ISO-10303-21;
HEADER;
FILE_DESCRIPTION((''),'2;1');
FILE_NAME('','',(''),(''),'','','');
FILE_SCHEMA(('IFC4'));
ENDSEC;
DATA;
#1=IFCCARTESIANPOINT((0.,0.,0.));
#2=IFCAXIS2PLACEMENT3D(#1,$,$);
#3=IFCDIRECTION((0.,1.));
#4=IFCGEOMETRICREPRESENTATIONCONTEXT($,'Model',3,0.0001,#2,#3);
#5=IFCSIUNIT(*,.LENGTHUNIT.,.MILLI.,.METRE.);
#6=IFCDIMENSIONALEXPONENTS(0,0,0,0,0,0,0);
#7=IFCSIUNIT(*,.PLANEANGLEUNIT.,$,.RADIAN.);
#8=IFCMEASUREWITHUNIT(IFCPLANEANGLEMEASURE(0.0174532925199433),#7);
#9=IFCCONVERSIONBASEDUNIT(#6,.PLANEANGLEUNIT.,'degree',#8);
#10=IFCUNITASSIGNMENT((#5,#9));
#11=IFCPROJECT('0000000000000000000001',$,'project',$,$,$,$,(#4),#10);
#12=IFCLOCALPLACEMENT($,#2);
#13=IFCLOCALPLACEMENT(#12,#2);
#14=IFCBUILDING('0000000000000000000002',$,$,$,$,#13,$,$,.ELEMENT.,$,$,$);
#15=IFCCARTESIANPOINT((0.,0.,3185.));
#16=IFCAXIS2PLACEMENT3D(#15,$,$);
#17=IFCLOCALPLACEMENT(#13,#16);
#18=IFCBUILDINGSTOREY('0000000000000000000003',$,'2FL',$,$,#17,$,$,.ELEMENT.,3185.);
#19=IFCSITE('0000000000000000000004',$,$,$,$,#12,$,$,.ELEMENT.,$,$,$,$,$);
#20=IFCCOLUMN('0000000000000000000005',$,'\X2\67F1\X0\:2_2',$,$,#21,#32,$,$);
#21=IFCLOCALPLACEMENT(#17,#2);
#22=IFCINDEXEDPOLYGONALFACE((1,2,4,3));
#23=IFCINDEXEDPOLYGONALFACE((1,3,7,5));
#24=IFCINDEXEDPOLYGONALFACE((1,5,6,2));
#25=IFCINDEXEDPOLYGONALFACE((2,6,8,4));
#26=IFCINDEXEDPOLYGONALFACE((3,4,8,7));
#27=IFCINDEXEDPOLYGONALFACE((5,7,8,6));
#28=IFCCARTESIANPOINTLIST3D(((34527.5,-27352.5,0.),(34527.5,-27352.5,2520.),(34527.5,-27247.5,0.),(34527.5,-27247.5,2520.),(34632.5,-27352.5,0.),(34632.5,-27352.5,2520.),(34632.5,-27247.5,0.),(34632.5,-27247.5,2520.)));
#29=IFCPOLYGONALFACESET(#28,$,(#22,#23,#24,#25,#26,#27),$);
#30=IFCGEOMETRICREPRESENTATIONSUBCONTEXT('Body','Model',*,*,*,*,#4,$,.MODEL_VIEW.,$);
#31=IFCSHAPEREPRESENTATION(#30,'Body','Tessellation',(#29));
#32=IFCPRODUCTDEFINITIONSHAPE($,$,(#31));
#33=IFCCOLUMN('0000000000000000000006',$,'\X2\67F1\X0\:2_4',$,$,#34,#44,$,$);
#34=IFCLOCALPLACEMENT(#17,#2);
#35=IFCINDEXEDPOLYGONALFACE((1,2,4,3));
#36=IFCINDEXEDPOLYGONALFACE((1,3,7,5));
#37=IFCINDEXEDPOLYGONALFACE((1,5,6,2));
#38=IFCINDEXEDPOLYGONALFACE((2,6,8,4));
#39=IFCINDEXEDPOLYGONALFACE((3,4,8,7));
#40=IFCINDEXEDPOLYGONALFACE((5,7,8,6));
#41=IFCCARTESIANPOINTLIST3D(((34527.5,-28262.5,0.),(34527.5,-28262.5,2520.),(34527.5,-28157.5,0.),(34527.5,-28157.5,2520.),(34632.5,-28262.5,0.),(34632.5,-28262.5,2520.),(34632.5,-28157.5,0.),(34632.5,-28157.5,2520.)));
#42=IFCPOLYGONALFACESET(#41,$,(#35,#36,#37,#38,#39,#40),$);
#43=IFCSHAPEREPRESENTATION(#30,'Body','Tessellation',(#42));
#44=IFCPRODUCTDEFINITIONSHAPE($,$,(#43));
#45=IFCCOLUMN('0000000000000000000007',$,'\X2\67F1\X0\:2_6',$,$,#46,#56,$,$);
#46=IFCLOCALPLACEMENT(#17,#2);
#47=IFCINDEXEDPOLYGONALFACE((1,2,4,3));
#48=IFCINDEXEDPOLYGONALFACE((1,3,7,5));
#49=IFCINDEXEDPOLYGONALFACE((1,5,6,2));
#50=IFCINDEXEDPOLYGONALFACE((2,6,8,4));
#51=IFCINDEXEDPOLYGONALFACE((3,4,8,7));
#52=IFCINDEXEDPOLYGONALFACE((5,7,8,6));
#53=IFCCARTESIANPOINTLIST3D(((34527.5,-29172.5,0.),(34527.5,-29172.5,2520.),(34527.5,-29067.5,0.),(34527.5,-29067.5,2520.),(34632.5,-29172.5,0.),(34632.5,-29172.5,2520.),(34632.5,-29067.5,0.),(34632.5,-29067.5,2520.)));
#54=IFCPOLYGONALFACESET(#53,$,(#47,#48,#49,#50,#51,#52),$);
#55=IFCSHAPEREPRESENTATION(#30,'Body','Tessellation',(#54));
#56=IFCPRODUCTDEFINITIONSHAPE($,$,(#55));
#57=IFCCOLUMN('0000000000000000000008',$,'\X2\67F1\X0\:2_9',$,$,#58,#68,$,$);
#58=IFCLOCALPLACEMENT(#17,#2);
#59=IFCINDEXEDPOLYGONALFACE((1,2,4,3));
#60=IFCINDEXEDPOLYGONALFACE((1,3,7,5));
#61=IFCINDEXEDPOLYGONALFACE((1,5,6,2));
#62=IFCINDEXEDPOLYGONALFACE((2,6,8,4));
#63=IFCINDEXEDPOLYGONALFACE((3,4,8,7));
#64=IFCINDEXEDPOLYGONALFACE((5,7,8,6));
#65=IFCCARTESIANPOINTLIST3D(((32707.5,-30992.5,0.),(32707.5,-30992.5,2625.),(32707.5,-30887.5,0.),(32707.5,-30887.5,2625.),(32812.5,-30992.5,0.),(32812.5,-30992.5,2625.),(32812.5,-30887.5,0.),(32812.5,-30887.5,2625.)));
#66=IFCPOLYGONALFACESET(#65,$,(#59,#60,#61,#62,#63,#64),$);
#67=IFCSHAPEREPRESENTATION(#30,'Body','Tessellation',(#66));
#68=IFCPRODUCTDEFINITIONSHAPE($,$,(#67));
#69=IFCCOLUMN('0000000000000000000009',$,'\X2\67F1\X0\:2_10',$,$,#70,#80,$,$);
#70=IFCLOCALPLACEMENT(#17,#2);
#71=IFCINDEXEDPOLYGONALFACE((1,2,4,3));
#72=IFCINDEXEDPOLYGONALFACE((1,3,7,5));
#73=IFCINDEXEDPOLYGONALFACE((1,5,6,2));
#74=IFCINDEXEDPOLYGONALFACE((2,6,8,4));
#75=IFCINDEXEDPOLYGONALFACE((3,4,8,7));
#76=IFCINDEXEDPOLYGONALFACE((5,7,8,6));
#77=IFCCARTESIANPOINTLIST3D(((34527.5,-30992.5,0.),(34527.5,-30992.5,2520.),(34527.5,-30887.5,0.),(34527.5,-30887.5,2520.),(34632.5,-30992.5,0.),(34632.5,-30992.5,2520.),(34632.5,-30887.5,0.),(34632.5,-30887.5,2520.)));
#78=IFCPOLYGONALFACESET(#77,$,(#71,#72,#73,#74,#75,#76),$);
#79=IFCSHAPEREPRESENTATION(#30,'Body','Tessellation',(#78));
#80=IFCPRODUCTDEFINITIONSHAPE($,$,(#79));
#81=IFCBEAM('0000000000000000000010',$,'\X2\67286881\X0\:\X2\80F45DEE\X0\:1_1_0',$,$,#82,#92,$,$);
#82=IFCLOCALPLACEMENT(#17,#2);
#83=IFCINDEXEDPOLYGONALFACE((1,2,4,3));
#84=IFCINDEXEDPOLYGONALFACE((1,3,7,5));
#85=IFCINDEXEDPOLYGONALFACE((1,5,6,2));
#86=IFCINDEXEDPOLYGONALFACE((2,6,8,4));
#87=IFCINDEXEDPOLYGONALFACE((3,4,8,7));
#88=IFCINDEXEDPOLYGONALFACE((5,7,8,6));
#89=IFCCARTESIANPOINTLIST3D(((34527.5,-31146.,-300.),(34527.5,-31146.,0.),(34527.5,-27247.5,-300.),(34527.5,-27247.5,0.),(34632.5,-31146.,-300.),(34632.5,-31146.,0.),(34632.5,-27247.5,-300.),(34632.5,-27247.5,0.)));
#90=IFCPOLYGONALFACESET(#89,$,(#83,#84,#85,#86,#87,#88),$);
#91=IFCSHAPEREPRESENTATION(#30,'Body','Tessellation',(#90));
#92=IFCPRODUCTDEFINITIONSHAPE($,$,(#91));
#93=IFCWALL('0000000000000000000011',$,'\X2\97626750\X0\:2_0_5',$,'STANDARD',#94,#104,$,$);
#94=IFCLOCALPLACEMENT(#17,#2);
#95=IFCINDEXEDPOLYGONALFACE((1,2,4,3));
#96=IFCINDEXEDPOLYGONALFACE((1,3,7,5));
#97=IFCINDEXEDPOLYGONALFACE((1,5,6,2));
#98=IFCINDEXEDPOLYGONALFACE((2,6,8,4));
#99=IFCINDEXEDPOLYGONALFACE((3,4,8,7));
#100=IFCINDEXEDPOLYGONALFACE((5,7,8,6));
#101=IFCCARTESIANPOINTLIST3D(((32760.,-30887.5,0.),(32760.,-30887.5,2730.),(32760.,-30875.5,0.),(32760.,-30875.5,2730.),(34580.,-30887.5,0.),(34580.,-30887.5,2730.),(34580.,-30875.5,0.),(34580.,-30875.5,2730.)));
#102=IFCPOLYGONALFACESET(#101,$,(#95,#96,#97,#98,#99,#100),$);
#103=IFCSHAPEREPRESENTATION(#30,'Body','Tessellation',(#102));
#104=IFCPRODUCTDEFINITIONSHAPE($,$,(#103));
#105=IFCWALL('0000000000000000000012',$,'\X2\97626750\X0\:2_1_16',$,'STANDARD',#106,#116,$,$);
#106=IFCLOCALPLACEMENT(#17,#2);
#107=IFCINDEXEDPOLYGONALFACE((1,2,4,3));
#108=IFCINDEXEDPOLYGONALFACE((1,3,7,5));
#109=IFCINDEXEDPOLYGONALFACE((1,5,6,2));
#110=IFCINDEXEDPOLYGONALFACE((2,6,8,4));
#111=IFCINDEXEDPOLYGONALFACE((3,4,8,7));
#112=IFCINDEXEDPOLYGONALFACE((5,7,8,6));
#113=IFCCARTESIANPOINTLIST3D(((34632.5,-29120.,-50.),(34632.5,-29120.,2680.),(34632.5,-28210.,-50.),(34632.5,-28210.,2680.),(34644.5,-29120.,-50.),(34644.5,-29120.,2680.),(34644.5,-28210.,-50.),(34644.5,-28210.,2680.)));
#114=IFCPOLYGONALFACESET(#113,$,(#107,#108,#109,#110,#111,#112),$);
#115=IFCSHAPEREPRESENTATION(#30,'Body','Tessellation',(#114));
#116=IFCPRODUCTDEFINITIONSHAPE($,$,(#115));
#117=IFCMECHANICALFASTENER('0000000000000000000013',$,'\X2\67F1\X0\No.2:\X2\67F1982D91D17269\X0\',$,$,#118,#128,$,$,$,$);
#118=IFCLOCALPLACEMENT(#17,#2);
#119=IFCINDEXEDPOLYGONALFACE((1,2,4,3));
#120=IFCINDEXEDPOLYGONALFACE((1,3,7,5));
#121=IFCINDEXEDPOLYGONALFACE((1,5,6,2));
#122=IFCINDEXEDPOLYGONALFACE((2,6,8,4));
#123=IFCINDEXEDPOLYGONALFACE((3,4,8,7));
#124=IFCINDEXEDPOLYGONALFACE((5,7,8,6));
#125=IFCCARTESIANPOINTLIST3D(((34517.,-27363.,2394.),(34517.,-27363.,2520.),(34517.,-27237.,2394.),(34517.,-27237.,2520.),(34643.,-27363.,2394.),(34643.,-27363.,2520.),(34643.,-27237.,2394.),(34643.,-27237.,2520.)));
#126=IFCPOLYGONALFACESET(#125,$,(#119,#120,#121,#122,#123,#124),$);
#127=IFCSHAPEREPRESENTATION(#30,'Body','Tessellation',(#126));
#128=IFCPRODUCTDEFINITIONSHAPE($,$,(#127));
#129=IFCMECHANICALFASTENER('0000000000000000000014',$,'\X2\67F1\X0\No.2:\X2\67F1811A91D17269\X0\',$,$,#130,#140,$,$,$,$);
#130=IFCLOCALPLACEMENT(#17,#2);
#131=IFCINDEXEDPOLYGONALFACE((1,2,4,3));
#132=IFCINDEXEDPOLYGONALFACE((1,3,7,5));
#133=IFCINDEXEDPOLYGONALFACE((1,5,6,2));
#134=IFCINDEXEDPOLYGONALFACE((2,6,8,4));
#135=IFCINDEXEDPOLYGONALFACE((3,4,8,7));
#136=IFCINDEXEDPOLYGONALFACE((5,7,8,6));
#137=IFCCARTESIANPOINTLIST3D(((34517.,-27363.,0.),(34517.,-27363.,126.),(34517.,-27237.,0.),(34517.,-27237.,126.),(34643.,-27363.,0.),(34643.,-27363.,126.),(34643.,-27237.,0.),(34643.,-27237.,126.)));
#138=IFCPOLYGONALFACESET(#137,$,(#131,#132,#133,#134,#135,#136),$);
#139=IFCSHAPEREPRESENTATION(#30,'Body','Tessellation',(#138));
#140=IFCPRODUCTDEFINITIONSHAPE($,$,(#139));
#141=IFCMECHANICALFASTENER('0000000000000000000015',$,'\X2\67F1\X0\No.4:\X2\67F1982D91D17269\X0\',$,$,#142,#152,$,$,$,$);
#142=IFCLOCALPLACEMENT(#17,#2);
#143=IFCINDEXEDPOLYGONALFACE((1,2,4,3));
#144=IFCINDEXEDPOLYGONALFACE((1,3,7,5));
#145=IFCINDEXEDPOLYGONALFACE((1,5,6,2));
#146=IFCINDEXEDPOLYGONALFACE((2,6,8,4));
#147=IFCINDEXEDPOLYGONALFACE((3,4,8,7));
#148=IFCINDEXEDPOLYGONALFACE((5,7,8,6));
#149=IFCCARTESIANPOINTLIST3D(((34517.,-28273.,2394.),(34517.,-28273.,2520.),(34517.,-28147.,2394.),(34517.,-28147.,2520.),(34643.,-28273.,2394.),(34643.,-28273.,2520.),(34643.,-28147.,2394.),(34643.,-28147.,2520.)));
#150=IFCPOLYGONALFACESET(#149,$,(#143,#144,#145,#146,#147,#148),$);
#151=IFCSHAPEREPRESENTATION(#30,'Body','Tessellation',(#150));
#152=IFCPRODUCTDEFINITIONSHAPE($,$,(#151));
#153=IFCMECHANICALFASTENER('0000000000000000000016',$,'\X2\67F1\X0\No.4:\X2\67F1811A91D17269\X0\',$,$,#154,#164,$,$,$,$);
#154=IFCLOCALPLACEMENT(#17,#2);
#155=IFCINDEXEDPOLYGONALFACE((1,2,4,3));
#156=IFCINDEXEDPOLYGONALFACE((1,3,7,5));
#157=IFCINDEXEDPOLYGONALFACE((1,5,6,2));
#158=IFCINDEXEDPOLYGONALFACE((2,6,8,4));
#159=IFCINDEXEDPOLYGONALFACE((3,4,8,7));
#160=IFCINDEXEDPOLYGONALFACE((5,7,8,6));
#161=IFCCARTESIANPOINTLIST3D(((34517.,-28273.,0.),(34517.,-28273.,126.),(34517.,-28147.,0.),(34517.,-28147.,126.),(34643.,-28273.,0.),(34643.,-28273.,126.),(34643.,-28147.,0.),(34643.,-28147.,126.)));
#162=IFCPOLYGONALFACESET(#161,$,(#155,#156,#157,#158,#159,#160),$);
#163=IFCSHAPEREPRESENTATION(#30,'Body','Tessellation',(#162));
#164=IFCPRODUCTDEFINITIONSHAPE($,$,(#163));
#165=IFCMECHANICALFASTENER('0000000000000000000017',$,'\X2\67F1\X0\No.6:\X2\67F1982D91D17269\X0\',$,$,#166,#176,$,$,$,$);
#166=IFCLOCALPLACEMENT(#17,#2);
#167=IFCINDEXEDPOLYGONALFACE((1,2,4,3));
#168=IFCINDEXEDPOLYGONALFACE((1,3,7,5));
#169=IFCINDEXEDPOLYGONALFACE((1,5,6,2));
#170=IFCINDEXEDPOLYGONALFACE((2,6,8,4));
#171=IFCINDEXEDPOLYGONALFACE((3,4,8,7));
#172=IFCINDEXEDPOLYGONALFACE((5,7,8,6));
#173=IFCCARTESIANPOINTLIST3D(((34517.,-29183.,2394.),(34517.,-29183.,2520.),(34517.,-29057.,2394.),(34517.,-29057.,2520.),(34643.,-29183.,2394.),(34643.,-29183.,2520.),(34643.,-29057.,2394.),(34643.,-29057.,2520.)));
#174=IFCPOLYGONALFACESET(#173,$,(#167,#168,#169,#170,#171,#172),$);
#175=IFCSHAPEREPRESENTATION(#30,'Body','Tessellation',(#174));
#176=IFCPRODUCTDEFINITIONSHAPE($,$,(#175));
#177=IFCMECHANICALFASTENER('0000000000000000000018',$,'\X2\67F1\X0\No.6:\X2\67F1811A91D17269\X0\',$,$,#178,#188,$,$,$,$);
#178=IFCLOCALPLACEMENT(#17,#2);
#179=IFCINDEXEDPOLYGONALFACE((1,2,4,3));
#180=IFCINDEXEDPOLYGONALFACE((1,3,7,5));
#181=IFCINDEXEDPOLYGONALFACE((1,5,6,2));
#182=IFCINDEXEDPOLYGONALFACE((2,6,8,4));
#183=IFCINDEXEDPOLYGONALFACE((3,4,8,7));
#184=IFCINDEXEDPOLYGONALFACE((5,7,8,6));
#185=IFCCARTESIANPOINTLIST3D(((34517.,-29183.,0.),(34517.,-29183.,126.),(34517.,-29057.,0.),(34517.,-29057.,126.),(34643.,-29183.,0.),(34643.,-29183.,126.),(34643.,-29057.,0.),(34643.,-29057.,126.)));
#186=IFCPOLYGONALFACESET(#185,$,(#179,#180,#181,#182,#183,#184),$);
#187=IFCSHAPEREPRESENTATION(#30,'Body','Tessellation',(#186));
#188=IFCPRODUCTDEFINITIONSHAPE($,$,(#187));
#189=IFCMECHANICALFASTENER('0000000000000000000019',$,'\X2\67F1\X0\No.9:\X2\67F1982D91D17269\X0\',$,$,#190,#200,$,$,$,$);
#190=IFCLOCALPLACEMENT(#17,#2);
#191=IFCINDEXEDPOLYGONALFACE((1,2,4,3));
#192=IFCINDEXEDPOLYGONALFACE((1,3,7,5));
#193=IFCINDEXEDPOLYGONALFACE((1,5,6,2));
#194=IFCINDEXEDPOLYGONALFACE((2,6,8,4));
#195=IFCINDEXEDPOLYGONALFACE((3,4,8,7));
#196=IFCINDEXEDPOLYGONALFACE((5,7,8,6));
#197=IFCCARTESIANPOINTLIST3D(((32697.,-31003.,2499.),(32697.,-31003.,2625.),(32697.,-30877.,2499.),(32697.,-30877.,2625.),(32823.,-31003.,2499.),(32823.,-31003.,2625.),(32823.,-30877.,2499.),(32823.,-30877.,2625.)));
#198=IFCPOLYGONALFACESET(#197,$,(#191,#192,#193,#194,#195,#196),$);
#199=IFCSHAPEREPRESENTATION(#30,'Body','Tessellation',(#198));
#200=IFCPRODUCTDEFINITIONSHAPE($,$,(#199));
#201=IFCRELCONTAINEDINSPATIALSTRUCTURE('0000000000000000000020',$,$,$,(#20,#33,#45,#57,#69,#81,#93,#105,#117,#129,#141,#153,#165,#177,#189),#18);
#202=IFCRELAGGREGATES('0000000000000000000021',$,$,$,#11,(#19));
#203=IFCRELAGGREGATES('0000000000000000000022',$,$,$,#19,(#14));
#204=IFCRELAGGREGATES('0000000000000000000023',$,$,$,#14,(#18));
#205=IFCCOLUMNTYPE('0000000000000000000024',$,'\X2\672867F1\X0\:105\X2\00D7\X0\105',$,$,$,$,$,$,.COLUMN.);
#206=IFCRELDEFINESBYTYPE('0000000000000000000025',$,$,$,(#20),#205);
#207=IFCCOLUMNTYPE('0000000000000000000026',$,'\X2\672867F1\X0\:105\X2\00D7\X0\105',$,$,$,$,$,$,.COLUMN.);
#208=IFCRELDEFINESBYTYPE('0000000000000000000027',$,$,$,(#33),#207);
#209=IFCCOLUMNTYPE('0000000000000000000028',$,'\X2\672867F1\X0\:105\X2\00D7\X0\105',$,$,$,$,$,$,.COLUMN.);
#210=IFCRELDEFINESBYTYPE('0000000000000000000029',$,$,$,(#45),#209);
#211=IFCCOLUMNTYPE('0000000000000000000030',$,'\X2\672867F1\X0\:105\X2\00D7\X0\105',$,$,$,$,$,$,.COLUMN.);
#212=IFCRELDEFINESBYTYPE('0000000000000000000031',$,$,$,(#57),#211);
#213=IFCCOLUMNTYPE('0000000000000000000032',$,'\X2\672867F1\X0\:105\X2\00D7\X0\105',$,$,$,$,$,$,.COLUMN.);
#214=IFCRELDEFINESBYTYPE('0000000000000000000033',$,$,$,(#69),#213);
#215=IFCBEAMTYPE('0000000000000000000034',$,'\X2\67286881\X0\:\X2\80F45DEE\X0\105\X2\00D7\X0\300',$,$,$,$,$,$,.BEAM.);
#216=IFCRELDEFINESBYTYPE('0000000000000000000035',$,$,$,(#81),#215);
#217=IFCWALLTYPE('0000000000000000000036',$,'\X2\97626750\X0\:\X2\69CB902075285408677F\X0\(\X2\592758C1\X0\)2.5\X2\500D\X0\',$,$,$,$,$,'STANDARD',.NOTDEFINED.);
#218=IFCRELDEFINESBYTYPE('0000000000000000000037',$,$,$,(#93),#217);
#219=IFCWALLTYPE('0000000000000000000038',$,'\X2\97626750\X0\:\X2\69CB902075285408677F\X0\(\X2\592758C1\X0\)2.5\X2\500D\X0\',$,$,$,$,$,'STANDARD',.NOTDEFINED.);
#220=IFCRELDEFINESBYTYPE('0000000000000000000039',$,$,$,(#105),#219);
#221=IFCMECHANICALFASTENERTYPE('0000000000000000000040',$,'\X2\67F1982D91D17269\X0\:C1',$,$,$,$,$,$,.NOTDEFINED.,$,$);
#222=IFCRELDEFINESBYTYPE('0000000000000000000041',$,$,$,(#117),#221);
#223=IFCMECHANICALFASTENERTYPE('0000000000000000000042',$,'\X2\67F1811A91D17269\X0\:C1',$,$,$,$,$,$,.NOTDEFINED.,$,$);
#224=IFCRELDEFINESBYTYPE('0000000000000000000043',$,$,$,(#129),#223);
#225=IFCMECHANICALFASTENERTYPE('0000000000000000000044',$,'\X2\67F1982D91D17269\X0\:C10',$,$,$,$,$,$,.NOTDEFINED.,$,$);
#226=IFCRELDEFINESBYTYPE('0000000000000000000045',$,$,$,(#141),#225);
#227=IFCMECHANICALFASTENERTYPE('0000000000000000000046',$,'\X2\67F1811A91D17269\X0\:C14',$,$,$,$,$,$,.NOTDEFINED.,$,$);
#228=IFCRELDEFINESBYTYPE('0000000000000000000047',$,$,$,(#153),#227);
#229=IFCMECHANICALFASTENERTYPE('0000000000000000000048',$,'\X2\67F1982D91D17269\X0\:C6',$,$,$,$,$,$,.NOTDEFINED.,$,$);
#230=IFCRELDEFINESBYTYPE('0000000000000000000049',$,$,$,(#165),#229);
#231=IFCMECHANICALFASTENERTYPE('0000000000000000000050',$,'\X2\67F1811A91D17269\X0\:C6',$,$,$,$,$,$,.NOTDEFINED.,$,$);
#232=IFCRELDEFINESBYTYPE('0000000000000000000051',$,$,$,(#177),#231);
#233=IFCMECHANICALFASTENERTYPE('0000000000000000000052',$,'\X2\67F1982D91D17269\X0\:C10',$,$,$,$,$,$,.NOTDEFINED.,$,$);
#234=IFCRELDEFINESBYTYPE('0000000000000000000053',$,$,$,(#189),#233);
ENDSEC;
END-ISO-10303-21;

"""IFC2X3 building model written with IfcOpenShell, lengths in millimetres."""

from ifc_helpers import new_model, entity, si_unit, converted_unit, direction, frame, origin, origin_with_axes, origin_2d, place, context, subcontext, project, spatial, polyline, rectangle, outline, extrude, type_object, element, save


model = new_model("IFC2X3")

# Units and contexts
model_context = context("Model", 3, precision=0.0001, world=origin(), true_north=direction((0.0, 1.0)))
body_context = subcontext(model_context, "Body", "Model", "MODEL_VIEW")
ifc_project = project(units=[si_unit("LENGTHUNIT", "METRE", prefix="MILLI"), converted_unit("PLANEANGLEUNIT", "degree", entity("IfcPlaneAngleMeasure", 0.0174532925199433), si_unit("PLANEANGLEUNIT", "RADIAN"), dimensions=[0, 0, 0, 0, 0, 0, 0])], contexts=[model_context])

# Site, building, storey
site_placement = place(None, origin())
site = spatial("IfcSite", under=ifc_project, at=site_placement, CompositionType="ELEMENT")
building_placement = place(site_placement, origin())
building = spatial("IfcBuilding", under=site, at=building_placement, CompositionType="ELEMENT")
storey_placement = place(building_placement, frame((0.0, 0.0, 3185.0)))
storey = spatial("IfcBuildingStorey", under=building, at=storey_placement, Name="2FL", CompositionType="ELEMENT", Elevation=3185.0)

# Columns
column_type_1 = type_object("IfcColumnType", Name="木柱:105×105", PredefinedType="COLUMN")
column_1_placement = place(storey_placement, frame((34580.0, -27300.0, 0.0)))
element("IfcColumn", 1, at=column_1_placement, inside=storey, type_object=column_type_1, Name="柱:2_2", context=body_context, shape_type="SweptSolid", body=[
    extrude(rectangle(XDim=105.0, YDim=105.0, at=origin_2d()), origin_with_axes(), (0.0, 0.0, 1.0), 2520.0),
])
column_type_2 = type_object("IfcColumnType", Name="木柱:105×105", PredefinedType="COLUMN")
column_2_placement = place(storey_placement, frame((34580.0, -28210.0, 0.0)))
element("IfcColumn", 2, at=column_2_placement, inside=storey, type_object=column_type_2, Name="柱:2_4", context=body_context, shape_type="SweptSolid", body=[
    extrude(rectangle(XDim=105.0, YDim=105.0, at=origin_2d()), origin_with_axes(), (0.0, 0.0, 1.0), 2520.0),
])
column_type_3 = type_object("IfcColumnType", Name="木柱:105×105", PredefinedType="COLUMN")
column_3_placement = place(storey_placement, frame((34580.0, -29120.0, 0.0)))
element("IfcColumn", 3, at=column_3_placement, inside=storey, type_object=column_type_3, Name="柱:2_6", context=body_context, shape_type="SweptSolid", body=[
    extrude(rectangle(XDim=105.0, YDim=105.0, at=origin_2d()), origin_with_axes(), (0.0, 0.0, 1.0), 2520.0),
])
column_type_4 = type_object("IfcColumnType", Name="木柱:105×105", PredefinedType="COLUMN")
column_4_placement = place(storey_placement, frame((32760.0, -30940.0, 0.0)))
element("IfcColumn", 4, at=column_4_placement, inside=storey, type_object=column_type_4, Name="柱:2_9", context=body_context, shape_type="SweptSolid", body=[
    extrude(rectangle(XDim=105.0, YDim=105.0, at=origin_2d()), origin_with_axes(), (0.0, 0.0, 1.0), 2625.0),
])
column_type_5 = type_object("IfcColumnType", Name="木柱:105×105", PredefinedType="COLUMN")
column_5_placement = place(storey_placement, frame((34580.0, -30940.0, 0.0)))
element("IfcColumn", 5, at=column_5_placement, inside=storey, type_object=column_type_5, Name="柱:2_10", context=body_context, shape_type="SweptSolid", body=[
    extrude(rectangle(XDim=105.0, YDim=105.0, at=origin_2d()), origin_with_axes(), (0.0, 0.0, 1.0), 2520.0),
])

# Beam
beam_type = type_object("IfcBeamType", Name="木梁:胴差105×300", PredefinedType="BEAM")
beam_placement = place(storey_placement, frame((34580.0, -27247.5, -150.0), z_axis=(0.0, -1.0, 0.0), x_axis=(1.0, 0.0, 0.0)))
element("IfcBeam", 6, at=beam_placement, inside=storey, type_object=beam_type, Name="木梁:胴差:1_1_0", context=body_context, shape_type="SweptSolid", body=[
    extrude(rectangle(XDim=105.0, YDim=300.0, at=origin_2d()), origin_with_axes(), (0.0, 0.0, 1.0), 3898.5),
])

# Walls
wall_type_1 = type_object("IfcWallType", Name="面材:構造用合板(大壁)2.5倍", ElementType="STANDARD", PredefinedType="NOTDEFINED")
wall_1_placement = place(storey_placement, frame((33670.0, -30875.5, 0.0), z_axis=(0.0, -1.0, 0.0), x_axis=(1.0, 0.0, 0.0)))
element("IfcWall", 7, at=wall_1_placement, inside=storey, type_object=wall_type_1, Name="面材:2_0_5", ObjectType="STANDARD", context=body_context, shape_type="SweptSolid", body=[
    extrude(outline(polyline([(910.0, 0.0, 0.0), (-910.0, 0.0, 0.0), (-910.0, 2730.0, 0.0), (910.0, 2730.0, 0.0), (910.0, 0.0, 0.0)])), origin_with_axes(), (0.0, 0.0, 1.0), 12.0),
])
wall_type_2 = type_object("IfcWallType", Name="面材:構造用合板(大壁)2.5倍", ElementType="STANDARD", PredefinedType="NOTDEFINED")
wall_2_placement = place(storey_placement, frame((34644.5, -28665.0, -50.0), z_axis=(-1.0, 0.0, 0.0), x_axis=(0.0, -1.0, 0.0)))
element("IfcWall", 8, at=wall_2_placement, inside=storey, type_object=wall_type_2, Name="面材:2_1_16", ObjectType="STANDARD", context=body_context, shape_type="SweptSolid", body=[
    extrude(outline(polyline([(455.0, 0.0, 0.0), (-455.0, 0.0, 0.0), (-455.0, 2730.0, 0.0), (455.0, 2730.0, 0.0), (455.0, 0.0, 0.0)])), origin_with_axes(), (0.0, 0.0, 1.0), 12.0),
])

# Mechanical fasteners
mechanical_fastener_type_1 = type_object("IfcMechanicalFastenerType", Name="柱頭金物:C1")
mechanical_fastener_1_placement = place(storey_placement, frame((34580.0, -27300.0, 2394.0)))
element("IfcMechanicalFastener", 9, at=mechanical_fastener_1_placement, inside=storey, type_object=mechanical_fastener_type_1, Name="柱No.2:柱頭金物", context=body_context, shape_type="SweptSolid", body=[
    extrude(rectangle(XDim=126.0, YDim=126.0, at=origin_2d()), origin_with_axes(), (0.0, 0.0, 1.0), 126.0),
])
mechanical_fastener_type_2 = type_object("IfcMechanicalFastenerType", Name="柱脚金物:C1")
mechanical_fastener_2_placement = place(storey_placement, frame((34580.0, -27300.0, 0.0)))
element("IfcMechanicalFastener", 10, at=mechanical_fastener_2_placement, inside=storey, type_object=mechanical_fastener_type_2, Name="柱No.2:柱脚金物", context=body_context, shape_type="SweptSolid", body=[
    extrude(rectangle(XDim=126.0, YDim=126.0, at=origin_2d()), origin_with_axes(), (0.0, 0.0, 1.0), 126.0),
])
mechanical_fastener_type_3 = type_object("IfcMechanicalFastenerType", Name="柱頭金物:C10")
mechanical_fastener_3_placement = place(storey_placement, frame((34580.0, -28210.0, 2394.0)))
element("IfcMechanicalFastener", 11, at=mechanical_fastener_3_placement, inside=storey, type_object=mechanical_fastener_type_3, Name="柱No.4:柱頭金物", context=body_context, shape_type="SweptSolid", body=[
    extrude(rectangle(XDim=126.0, YDim=126.0, at=origin_2d()), origin_with_axes(), (0.0, 0.0, 1.0), 126.0),
])
mechanical_fastener_type_4 = type_object("IfcMechanicalFastenerType", Name="柱脚金物:C14")
mechanical_fastener_4_placement = place(storey_placement, frame((34580.0, -28210.0, 0.0)))
element("IfcMechanicalFastener", 12, at=mechanical_fastener_4_placement, inside=storey, type_object=mechanical_fastener_type_4, Name="柱No.4:柱脚金物", context=body_context, shape_type="SweptSolid", body=[
    extrude(rectangle(XDim=126.0, YDim=126.0, at=origin_2d()), origin_with_axes(), (0.0, 0.0, 1.0), 126.0),
])
mechanical_fastener_type_5 = type_object("IfcMechanicalFastenerType", Name="柱頭金物:C6")
mechanical_fastener_5_placement = place(storey_placement, frame((34580.0, -29120.0, 2394.0)))
element("IfcMechanicalFastener", 13, at=mechanical_fastener_5_placement, inside=storey, type_object=mechanical_fastener_type_5, Name="柱No.6:柱頭金物", context=body_context, shape_type="SweptSolid", body=[
    extrude(rectangle(XDim=126.0, YDim=126.0, at=origin_2d()), origin_with_axes(), (0.0, 0.0, 1.0), 126.0),
])
mechanical_fastener_type_6 = type_object("IfcMechanicalFastenerType", Name="柱脚金物:C6")
mechanical_fastener_6_placement = place(storey_placement, frame((34580.0, -29120.0, 0.0)))
element("IfcMechanicalFastener", 14, at=mechanical_fastener_6_placement, inside=storey, type_object=mechanical_fastener_type_6, Name="柱No.6:柱脚金物", context=body_context, shape_type="SweptSolid", body=[
    extrude(rectangle(XDim=126.0, YDim=126.0, at=origin_2d()), origin_with_axes(), (0.0, 0.0, 1.0), 126.0),
])
mechanical_fastener_type_7 = type_object("IfcMechanicalFastenerType", Name="柱頭金物:C10")
mechanical_fastener_7_placement = place(storey_placement, frame((32760.0, -30940.0, 2499.0)))
element("IfcMechanicalFastener", 15, at=mechanical_fastener_7_placement, inside=storey, type_object=mechanical_fastener_type_7, Name="柱No.9:柱頭金物", context=body_context, shape_type="SweptSolid", body=[
    extrude(rectangle(XDim=126.0, YDim=126.0, at=origin_2d()), origin_with_axes(), (0.0, 0.0, 1.0), 126.0),
])

save(model, "model.ifc")
